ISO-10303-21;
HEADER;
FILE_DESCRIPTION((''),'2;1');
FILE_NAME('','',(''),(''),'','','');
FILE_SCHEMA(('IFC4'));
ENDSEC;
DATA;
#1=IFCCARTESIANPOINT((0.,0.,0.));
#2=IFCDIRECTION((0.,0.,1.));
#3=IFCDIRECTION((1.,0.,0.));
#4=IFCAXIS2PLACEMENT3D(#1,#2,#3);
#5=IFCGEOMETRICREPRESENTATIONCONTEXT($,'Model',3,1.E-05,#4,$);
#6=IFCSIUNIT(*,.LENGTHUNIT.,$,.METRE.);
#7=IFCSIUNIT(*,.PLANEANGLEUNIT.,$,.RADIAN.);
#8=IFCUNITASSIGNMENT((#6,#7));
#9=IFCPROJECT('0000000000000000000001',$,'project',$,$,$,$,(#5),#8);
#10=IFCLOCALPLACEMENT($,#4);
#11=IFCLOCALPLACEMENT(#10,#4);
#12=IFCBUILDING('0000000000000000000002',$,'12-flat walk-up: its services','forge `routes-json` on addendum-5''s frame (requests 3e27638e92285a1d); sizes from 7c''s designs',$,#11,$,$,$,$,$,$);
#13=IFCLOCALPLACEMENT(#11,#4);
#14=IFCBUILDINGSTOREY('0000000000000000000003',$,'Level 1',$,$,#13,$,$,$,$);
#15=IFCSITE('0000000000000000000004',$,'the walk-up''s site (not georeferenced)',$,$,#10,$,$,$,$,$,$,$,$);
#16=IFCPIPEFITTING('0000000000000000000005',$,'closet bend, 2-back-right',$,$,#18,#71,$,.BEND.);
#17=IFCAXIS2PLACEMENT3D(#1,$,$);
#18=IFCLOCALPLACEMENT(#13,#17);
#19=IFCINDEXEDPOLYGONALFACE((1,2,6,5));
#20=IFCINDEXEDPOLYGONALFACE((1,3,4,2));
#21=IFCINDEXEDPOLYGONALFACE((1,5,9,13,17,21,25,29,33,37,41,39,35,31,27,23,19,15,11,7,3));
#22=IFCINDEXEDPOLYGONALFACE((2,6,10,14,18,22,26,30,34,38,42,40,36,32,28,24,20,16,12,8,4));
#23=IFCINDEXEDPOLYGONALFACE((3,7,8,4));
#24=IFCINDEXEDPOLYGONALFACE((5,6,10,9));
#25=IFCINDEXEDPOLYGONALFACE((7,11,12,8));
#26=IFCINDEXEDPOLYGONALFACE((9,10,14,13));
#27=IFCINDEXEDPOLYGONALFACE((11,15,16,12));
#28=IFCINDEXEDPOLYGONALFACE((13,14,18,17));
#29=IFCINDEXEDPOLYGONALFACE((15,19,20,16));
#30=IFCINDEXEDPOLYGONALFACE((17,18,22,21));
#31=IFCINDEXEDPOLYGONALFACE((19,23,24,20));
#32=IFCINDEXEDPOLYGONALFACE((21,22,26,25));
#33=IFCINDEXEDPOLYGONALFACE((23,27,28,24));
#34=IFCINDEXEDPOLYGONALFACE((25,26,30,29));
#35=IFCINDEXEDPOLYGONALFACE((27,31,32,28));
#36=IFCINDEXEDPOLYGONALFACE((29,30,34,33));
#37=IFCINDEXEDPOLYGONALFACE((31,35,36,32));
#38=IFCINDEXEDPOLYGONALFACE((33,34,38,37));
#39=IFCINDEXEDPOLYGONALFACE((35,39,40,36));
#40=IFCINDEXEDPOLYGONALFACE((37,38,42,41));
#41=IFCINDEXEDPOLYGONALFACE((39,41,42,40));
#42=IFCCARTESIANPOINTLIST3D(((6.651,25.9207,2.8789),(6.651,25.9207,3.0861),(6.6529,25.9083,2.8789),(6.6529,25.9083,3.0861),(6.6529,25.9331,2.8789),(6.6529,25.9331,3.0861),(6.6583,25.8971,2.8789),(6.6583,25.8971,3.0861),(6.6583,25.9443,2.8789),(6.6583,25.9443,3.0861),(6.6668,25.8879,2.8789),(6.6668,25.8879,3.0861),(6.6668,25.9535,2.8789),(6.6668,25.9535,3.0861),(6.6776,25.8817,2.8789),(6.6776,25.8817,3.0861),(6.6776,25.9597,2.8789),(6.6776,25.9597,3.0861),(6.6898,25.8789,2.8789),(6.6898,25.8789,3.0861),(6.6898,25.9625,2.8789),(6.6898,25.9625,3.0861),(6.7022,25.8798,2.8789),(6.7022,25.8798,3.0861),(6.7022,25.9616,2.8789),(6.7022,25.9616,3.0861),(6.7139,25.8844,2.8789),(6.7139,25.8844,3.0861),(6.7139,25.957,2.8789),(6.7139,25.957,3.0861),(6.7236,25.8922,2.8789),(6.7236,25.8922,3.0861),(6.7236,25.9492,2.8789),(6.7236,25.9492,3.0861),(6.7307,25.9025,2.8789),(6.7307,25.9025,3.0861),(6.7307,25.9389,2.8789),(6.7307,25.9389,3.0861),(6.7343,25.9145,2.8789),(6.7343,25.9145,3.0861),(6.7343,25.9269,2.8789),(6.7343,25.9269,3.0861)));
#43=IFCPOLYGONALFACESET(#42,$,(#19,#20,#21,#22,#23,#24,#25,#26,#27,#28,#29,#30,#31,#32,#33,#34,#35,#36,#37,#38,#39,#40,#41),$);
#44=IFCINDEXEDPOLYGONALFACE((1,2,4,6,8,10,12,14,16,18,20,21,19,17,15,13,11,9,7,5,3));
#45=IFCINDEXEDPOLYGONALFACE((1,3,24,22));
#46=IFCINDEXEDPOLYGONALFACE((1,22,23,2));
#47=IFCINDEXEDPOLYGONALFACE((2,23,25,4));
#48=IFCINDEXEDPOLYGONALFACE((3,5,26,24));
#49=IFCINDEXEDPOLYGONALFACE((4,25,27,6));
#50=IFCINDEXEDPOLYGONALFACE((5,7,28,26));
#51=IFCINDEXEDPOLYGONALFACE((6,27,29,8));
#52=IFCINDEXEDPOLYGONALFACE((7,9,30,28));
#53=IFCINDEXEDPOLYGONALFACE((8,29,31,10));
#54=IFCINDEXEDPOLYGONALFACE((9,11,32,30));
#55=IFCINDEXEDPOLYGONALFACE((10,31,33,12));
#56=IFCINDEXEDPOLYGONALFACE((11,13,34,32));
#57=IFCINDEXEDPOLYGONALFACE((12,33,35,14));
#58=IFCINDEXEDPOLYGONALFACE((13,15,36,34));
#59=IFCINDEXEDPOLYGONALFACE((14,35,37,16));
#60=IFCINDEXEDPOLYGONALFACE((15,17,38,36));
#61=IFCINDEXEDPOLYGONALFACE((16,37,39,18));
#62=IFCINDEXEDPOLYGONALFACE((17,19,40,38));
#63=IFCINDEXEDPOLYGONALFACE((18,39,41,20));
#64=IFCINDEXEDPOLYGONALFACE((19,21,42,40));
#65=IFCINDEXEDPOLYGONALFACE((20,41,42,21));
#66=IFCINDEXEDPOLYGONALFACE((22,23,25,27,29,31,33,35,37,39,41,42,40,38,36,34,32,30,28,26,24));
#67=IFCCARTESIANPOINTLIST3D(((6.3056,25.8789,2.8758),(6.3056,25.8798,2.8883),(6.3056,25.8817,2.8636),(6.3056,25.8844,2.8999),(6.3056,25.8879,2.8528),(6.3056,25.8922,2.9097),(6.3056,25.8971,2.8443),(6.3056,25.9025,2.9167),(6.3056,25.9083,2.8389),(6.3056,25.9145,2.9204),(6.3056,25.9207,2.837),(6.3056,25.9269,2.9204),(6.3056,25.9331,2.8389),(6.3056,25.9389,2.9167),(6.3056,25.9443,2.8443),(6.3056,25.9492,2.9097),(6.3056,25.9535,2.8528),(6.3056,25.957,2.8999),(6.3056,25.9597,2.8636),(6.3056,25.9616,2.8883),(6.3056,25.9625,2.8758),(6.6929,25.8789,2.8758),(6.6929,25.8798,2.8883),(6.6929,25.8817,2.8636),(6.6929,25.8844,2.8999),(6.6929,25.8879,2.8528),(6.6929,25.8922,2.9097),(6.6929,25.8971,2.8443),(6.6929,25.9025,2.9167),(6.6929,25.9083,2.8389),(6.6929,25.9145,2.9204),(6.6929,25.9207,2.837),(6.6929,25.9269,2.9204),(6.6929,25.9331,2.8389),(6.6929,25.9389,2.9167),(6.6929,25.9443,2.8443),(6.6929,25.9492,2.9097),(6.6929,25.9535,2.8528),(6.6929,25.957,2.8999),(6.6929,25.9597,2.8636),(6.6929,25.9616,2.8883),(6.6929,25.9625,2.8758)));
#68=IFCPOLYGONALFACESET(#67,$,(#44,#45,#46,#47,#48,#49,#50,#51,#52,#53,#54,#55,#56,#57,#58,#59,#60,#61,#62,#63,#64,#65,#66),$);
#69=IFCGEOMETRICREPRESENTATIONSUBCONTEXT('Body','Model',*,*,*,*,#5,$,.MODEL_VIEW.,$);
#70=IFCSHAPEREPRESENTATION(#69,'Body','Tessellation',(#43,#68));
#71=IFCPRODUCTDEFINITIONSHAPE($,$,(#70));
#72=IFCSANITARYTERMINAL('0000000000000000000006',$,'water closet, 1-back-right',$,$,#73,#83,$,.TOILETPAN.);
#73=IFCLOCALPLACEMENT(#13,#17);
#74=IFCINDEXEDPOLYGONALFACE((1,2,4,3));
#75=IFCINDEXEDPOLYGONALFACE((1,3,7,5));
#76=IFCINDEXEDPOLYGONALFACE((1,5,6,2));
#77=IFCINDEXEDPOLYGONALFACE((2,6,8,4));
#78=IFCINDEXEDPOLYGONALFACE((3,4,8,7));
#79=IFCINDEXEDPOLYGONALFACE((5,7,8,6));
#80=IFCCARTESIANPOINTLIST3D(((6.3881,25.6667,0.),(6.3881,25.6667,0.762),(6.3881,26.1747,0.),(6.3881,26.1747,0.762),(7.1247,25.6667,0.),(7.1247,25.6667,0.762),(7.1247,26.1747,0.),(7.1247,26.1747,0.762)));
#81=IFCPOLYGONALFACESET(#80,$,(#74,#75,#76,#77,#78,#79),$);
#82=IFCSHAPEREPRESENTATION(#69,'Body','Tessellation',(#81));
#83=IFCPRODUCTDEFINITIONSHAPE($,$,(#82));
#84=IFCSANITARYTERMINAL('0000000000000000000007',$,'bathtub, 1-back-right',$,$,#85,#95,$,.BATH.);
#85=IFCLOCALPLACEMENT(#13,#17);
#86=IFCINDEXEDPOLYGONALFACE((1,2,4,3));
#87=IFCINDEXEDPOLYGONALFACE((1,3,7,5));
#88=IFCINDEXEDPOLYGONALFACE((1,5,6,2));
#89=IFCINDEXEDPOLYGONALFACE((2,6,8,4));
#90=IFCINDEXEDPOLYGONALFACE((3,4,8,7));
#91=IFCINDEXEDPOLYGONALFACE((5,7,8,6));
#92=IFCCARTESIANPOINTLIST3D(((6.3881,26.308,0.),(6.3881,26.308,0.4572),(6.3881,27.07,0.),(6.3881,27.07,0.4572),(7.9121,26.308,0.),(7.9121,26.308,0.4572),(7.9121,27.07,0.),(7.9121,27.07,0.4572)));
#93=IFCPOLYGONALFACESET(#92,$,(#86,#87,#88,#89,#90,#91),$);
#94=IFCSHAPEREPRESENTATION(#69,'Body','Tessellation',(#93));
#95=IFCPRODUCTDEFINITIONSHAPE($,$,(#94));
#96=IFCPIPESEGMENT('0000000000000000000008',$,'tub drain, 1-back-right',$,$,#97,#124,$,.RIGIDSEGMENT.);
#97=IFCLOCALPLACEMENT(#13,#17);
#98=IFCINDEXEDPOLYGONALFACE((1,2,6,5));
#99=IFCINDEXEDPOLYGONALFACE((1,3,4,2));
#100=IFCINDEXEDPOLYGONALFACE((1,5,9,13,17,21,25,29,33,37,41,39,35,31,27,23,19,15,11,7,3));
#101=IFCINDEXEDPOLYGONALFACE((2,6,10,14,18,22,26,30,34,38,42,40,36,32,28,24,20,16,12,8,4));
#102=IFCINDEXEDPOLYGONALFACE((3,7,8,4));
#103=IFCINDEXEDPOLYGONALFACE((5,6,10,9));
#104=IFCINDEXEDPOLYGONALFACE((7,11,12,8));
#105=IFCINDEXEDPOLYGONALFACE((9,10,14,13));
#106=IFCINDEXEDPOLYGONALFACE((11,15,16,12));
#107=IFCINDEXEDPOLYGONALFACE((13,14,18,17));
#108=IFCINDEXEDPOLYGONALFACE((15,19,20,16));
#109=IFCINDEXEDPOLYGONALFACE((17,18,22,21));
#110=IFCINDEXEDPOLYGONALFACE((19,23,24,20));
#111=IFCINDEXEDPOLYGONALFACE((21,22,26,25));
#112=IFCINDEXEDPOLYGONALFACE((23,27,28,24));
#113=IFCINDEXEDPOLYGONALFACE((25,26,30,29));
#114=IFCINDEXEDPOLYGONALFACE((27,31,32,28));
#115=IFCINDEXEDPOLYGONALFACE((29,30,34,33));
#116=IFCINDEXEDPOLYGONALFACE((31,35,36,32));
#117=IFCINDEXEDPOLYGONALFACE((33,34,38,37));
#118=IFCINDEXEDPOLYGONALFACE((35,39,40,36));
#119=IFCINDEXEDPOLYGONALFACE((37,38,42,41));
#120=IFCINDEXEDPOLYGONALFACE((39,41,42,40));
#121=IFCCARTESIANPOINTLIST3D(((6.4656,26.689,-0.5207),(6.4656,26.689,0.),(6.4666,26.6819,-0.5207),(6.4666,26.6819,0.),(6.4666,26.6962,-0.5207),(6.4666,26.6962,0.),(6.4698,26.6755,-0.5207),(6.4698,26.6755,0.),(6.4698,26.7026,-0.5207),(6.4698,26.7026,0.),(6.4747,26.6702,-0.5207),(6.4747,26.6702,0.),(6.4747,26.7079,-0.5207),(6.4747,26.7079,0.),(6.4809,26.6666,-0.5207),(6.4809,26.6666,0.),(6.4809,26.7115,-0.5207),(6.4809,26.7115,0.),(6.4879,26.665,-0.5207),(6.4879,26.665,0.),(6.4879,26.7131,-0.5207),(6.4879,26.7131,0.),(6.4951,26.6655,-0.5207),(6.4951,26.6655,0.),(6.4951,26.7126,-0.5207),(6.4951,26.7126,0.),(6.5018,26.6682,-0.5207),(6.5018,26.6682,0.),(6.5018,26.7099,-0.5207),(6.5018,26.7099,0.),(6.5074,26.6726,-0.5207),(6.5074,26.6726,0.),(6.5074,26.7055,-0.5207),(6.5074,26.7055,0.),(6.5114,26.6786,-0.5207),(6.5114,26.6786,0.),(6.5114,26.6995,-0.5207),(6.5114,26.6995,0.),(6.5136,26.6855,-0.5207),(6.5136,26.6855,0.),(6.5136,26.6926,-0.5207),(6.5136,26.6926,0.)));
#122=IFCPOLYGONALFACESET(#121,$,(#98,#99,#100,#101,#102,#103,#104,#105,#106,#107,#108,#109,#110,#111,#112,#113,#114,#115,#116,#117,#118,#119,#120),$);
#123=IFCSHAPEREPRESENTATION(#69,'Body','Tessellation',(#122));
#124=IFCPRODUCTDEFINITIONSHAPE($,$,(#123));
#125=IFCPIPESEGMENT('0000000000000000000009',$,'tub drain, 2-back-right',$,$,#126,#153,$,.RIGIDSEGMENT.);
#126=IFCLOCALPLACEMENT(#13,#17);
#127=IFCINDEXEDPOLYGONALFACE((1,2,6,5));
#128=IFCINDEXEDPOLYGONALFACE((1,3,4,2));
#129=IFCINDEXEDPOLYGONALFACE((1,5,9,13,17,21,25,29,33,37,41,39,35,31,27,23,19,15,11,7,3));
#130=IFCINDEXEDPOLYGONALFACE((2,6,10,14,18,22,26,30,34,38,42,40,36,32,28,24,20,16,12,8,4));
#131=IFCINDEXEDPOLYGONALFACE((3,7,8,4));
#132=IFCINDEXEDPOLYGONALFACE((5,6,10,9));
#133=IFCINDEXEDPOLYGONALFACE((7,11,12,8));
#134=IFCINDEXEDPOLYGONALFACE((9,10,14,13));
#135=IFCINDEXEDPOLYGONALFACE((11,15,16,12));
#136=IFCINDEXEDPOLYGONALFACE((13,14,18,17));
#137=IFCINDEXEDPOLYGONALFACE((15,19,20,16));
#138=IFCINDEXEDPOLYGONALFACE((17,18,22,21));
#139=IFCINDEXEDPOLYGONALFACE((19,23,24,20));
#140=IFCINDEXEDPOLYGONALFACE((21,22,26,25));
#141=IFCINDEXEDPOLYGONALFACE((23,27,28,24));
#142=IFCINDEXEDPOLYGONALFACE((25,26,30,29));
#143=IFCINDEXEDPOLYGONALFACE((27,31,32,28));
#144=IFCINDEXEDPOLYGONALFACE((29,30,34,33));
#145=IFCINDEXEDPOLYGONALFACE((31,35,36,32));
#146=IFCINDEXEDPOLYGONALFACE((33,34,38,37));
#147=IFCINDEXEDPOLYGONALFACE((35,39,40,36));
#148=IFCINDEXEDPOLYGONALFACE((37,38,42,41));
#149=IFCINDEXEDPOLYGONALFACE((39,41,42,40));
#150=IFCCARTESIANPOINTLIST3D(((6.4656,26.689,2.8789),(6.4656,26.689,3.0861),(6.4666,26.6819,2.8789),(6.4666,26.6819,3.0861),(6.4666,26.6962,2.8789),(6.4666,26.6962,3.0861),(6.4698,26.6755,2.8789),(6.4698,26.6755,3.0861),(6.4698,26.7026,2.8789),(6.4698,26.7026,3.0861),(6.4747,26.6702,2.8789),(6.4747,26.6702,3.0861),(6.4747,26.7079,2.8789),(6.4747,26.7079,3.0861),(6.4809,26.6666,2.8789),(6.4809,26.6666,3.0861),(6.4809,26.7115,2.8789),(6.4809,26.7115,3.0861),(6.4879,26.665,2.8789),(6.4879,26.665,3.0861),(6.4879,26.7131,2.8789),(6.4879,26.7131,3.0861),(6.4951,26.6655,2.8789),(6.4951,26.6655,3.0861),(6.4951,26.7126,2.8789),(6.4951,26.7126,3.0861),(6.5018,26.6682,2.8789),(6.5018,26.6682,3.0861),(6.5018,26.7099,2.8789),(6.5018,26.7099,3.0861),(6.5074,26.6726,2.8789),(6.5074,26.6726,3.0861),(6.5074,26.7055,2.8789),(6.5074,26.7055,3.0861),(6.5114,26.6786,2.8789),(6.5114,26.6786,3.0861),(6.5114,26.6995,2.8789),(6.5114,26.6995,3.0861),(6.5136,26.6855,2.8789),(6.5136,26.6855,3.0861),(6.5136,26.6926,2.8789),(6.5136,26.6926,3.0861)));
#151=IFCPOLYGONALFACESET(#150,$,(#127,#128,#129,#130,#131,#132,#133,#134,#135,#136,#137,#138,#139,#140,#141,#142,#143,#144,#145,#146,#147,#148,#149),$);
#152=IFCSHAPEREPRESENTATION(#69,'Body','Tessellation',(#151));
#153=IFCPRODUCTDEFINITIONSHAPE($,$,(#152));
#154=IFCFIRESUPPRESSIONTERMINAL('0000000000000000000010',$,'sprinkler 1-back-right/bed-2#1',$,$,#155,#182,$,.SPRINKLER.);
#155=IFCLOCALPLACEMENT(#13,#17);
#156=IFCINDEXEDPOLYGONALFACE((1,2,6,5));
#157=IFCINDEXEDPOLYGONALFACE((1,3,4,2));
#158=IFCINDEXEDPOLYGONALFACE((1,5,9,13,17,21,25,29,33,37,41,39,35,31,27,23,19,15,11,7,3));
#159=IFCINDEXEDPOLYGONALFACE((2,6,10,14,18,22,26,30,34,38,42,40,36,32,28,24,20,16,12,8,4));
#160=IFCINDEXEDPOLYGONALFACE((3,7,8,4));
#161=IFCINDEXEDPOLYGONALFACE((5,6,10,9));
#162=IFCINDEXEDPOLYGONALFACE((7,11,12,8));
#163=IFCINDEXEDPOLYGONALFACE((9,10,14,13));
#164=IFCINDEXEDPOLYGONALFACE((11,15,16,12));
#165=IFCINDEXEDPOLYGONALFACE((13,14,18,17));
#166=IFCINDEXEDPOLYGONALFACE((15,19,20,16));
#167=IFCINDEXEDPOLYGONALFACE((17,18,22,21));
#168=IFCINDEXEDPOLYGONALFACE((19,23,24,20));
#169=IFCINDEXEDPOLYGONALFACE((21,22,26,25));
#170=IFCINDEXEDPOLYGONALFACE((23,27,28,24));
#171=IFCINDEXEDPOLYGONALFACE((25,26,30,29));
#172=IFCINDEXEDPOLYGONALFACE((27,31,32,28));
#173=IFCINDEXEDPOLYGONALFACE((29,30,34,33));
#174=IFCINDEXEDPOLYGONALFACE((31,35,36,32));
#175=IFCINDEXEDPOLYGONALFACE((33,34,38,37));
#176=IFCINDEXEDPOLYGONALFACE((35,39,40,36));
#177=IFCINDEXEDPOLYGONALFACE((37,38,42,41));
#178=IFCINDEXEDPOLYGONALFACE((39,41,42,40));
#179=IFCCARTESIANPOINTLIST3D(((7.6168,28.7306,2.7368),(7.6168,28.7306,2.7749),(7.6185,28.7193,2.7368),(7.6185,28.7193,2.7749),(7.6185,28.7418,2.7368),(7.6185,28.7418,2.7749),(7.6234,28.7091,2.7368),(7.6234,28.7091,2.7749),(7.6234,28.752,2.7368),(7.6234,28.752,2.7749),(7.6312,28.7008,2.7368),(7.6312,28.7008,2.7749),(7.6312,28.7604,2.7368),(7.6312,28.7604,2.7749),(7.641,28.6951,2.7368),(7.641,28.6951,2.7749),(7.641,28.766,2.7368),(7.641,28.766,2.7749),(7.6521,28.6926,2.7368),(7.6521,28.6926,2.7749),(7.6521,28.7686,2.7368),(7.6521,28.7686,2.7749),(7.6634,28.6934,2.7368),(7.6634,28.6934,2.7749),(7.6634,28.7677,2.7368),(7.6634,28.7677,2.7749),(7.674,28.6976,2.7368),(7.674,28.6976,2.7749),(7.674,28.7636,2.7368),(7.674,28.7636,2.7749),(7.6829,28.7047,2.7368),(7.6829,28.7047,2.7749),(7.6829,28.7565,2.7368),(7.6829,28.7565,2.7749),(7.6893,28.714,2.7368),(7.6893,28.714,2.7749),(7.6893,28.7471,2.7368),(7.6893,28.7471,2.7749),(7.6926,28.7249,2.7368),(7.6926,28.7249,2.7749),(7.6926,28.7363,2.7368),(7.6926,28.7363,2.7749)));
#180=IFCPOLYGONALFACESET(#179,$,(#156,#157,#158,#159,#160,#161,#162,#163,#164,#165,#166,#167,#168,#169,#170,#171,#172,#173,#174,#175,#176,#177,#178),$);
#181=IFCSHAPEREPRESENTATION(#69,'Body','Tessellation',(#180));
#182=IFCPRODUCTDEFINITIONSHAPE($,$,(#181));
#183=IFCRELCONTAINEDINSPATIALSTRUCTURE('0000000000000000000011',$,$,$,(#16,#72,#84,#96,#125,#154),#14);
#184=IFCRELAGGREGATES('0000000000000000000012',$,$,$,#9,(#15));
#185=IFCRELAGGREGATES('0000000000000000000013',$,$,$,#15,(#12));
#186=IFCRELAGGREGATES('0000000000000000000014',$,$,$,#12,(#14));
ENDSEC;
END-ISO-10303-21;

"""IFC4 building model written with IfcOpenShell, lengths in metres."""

from ifc_helpers import new_model, entity, si_unit, frame, frame_2d, origin, origin_with_axes, place, context, subcontext, project, spatial, rectangle, extrude, element, save


model = new_model("IFC4")

# Units and contexts
model_context = context("Model", 3, precision=1e-05, world=origin_with_axes())
body_context = subcontext(model_context, "Body", "Model", "MODEL_VIEW")
ifc_project = project(units=[si_unit("LENGTHUNIT", "METRE"), si_unit("PLANEANGLEUNIT", "RADIAN")], contexts=[model_context])

# Site, building, storey
site_placement = place(None, origin_with_axes())
site = spatial("IfcSite", under=ifc_project, at=site_placement, Name="the walk-up's site (not georeferenced)")
building_placement = place(site_placement, origin_with_axes())
building = spatial("IfcBuilding", under=site, at=building_placement, Name="12-flat walk-up: its services", Description="forge `routes-json` on addendum-5's frame (requests 3e27638e92285a1d); sizes from 7c's designs")
storey_placement = place(building_placement, origin_with_axes())
storey = spatial("IfcBuildingStorey", under=building, at=storey_placement, Name="Level 1")

# Pipe fitting
pipe_fitting_1_placement = place(storey_placement, frame((6.6929, 25.9207, 3.0861), z_axis=(0.0, 0.0, 1.0), x_axis=(1.0, 0.0, 0.0)))
element("IfcPipeFitting", 1, at=pipe_fitting_1_placement, inside=storey, Name="closet bend, 2-back-right", PredefinedType="BEND", context=body_context, shape_type="AdvancedSweptSolid", body=[
    entity("IfcSweptDiskSolid", entity("IfcPolyline", [entity("IfcCartesianPoint", [0.0, 0.0, 0.0]), entity("IfcCartesianPoint", [0.0, 0.0, -0.2072])]), 0.0419),
    entity("IfcSweptDiskSolid", entity("IfcPolyline", [entity("IfcCartesianPoint", [0.0, 0.0, -0.2072]), entity("IfcCartesianPoint", [-0.3873, 0.0, -0.2072])]), 0.0419),
])

# Sanitary terminals
sanitary_terminal_1_placement = place(storey_placement, frame((6.3881, 25.6667, 0.0), z_axis=(0.0, 0.0, 1.0), x_axis=(1.0, 0.0, 0.0)))
element("IfcSanitaryTerminal", 2, at=sanitary_terminal_1_placement, inside=storey, Name="water closet, 1-back-right", PredefinedType="TOILETPAN", context=body_context, shape_type="SweptSolid", body=[
    extrude(rectangle(XDim=0.7366, YDim=0.508, at=frame_2d((0.3683, 0.254))), origin(), (0.0, 0.0, 1.0), 0.762),
])
sanitary_terminal_2_placement = place(storey_placement, frame((6.3881, 26.308, 0.0), z_axis=(0.0, 0.0, 1.0), x_axis=(1.0, 0.0, 0.0)))
element("IfcSanitaryTerminal", 3, at=sanitary_terminal_2_placement, inside=storey, Name="bathtub, 1-back-right", PredefinedType="BATH", context=body_context, shape_type="SweptSolid", body=[
    extrude(rectangle(XDim=1.524, YDim=0.762, at=frame_2d((0.762, 0.381))), origin(), (0.0, 0.0, 1.0), 0.4572),
])

# Pipe segments
pipe_segment_1_placement = place(storey_placement, frame((6.4897, 26.6891, 0.0), z_axis=(0.0, 0.0, 1.0), x_axis=(1.0, 0.0, 0.0)))
element("IfcPipeSegment", 4, at=pipe_segment_1_placement, inside=storey, Name="tub drain, 1-back-right", PredefinedType="RIGIDSEGMENT", context=body_context, shape_type="AdvancedSweptSolid", body=[
    entity("IfcSweptDiskSolid", entity("IfcPolyline", [entity("IfcCartesianPoint", [0.0, 0.0, 0.0]), entity("IfcCartesianPoint", [0.0, 0.0, -0.5207])]), 0.0241),
])
pipe_segment_2_placement = place(storey_placement, frame((6.4897, 26.6891, 3.0861), z_axis=(0.0, 0.0, 1.0), x_axis=(1.0, 0.0, 0.0)))
element("IfcPipeSegment", 5, at=pipe_segment_2_placement, inside=storey, Name="tub drain, 2-back-right", PredefinedType="RIGIDSEGMENT", context=body_context, shape_type="AdvancedSweptSolid", body=[
    entity("IfcSweptDiskSolid", entity("IfcPolyline", [entity("IfcCartesianPoint", [0.0, 0.0, 0.0]), entity("IfcCartesianPoint", [0.0, 0.0, -0.2072])]), 0.0241),
])

# Fire suppression terminal
fire_suppression_terminal_placement = place(storey_placement, frame((7.6549, 28.7306, 2.7749), z_axis=(0.0, 0.0, 1.0), x_axis=(1.0, 0.0, 0.0)))
element("IfcFireSuppressionTerminal", 6, at=fire_suppression_terminal_placement, inside=storey, Name="sprinkler 1-back-right/bed-2#1", PredefinedType="SPRINKLER", context=body_context, shape_type="AdvancedSweptSolid", body=[
    entity("IfcSweptDiskSolid", entity("IfcPolyline", [entity("IfcCartesianPoint", [0.0, 0.0, 0.0]), entity("IfcCartesianPoint", [0.0, 0.0, -0.0381])]), 0.0381),
])

save(model, "model.ifc")
